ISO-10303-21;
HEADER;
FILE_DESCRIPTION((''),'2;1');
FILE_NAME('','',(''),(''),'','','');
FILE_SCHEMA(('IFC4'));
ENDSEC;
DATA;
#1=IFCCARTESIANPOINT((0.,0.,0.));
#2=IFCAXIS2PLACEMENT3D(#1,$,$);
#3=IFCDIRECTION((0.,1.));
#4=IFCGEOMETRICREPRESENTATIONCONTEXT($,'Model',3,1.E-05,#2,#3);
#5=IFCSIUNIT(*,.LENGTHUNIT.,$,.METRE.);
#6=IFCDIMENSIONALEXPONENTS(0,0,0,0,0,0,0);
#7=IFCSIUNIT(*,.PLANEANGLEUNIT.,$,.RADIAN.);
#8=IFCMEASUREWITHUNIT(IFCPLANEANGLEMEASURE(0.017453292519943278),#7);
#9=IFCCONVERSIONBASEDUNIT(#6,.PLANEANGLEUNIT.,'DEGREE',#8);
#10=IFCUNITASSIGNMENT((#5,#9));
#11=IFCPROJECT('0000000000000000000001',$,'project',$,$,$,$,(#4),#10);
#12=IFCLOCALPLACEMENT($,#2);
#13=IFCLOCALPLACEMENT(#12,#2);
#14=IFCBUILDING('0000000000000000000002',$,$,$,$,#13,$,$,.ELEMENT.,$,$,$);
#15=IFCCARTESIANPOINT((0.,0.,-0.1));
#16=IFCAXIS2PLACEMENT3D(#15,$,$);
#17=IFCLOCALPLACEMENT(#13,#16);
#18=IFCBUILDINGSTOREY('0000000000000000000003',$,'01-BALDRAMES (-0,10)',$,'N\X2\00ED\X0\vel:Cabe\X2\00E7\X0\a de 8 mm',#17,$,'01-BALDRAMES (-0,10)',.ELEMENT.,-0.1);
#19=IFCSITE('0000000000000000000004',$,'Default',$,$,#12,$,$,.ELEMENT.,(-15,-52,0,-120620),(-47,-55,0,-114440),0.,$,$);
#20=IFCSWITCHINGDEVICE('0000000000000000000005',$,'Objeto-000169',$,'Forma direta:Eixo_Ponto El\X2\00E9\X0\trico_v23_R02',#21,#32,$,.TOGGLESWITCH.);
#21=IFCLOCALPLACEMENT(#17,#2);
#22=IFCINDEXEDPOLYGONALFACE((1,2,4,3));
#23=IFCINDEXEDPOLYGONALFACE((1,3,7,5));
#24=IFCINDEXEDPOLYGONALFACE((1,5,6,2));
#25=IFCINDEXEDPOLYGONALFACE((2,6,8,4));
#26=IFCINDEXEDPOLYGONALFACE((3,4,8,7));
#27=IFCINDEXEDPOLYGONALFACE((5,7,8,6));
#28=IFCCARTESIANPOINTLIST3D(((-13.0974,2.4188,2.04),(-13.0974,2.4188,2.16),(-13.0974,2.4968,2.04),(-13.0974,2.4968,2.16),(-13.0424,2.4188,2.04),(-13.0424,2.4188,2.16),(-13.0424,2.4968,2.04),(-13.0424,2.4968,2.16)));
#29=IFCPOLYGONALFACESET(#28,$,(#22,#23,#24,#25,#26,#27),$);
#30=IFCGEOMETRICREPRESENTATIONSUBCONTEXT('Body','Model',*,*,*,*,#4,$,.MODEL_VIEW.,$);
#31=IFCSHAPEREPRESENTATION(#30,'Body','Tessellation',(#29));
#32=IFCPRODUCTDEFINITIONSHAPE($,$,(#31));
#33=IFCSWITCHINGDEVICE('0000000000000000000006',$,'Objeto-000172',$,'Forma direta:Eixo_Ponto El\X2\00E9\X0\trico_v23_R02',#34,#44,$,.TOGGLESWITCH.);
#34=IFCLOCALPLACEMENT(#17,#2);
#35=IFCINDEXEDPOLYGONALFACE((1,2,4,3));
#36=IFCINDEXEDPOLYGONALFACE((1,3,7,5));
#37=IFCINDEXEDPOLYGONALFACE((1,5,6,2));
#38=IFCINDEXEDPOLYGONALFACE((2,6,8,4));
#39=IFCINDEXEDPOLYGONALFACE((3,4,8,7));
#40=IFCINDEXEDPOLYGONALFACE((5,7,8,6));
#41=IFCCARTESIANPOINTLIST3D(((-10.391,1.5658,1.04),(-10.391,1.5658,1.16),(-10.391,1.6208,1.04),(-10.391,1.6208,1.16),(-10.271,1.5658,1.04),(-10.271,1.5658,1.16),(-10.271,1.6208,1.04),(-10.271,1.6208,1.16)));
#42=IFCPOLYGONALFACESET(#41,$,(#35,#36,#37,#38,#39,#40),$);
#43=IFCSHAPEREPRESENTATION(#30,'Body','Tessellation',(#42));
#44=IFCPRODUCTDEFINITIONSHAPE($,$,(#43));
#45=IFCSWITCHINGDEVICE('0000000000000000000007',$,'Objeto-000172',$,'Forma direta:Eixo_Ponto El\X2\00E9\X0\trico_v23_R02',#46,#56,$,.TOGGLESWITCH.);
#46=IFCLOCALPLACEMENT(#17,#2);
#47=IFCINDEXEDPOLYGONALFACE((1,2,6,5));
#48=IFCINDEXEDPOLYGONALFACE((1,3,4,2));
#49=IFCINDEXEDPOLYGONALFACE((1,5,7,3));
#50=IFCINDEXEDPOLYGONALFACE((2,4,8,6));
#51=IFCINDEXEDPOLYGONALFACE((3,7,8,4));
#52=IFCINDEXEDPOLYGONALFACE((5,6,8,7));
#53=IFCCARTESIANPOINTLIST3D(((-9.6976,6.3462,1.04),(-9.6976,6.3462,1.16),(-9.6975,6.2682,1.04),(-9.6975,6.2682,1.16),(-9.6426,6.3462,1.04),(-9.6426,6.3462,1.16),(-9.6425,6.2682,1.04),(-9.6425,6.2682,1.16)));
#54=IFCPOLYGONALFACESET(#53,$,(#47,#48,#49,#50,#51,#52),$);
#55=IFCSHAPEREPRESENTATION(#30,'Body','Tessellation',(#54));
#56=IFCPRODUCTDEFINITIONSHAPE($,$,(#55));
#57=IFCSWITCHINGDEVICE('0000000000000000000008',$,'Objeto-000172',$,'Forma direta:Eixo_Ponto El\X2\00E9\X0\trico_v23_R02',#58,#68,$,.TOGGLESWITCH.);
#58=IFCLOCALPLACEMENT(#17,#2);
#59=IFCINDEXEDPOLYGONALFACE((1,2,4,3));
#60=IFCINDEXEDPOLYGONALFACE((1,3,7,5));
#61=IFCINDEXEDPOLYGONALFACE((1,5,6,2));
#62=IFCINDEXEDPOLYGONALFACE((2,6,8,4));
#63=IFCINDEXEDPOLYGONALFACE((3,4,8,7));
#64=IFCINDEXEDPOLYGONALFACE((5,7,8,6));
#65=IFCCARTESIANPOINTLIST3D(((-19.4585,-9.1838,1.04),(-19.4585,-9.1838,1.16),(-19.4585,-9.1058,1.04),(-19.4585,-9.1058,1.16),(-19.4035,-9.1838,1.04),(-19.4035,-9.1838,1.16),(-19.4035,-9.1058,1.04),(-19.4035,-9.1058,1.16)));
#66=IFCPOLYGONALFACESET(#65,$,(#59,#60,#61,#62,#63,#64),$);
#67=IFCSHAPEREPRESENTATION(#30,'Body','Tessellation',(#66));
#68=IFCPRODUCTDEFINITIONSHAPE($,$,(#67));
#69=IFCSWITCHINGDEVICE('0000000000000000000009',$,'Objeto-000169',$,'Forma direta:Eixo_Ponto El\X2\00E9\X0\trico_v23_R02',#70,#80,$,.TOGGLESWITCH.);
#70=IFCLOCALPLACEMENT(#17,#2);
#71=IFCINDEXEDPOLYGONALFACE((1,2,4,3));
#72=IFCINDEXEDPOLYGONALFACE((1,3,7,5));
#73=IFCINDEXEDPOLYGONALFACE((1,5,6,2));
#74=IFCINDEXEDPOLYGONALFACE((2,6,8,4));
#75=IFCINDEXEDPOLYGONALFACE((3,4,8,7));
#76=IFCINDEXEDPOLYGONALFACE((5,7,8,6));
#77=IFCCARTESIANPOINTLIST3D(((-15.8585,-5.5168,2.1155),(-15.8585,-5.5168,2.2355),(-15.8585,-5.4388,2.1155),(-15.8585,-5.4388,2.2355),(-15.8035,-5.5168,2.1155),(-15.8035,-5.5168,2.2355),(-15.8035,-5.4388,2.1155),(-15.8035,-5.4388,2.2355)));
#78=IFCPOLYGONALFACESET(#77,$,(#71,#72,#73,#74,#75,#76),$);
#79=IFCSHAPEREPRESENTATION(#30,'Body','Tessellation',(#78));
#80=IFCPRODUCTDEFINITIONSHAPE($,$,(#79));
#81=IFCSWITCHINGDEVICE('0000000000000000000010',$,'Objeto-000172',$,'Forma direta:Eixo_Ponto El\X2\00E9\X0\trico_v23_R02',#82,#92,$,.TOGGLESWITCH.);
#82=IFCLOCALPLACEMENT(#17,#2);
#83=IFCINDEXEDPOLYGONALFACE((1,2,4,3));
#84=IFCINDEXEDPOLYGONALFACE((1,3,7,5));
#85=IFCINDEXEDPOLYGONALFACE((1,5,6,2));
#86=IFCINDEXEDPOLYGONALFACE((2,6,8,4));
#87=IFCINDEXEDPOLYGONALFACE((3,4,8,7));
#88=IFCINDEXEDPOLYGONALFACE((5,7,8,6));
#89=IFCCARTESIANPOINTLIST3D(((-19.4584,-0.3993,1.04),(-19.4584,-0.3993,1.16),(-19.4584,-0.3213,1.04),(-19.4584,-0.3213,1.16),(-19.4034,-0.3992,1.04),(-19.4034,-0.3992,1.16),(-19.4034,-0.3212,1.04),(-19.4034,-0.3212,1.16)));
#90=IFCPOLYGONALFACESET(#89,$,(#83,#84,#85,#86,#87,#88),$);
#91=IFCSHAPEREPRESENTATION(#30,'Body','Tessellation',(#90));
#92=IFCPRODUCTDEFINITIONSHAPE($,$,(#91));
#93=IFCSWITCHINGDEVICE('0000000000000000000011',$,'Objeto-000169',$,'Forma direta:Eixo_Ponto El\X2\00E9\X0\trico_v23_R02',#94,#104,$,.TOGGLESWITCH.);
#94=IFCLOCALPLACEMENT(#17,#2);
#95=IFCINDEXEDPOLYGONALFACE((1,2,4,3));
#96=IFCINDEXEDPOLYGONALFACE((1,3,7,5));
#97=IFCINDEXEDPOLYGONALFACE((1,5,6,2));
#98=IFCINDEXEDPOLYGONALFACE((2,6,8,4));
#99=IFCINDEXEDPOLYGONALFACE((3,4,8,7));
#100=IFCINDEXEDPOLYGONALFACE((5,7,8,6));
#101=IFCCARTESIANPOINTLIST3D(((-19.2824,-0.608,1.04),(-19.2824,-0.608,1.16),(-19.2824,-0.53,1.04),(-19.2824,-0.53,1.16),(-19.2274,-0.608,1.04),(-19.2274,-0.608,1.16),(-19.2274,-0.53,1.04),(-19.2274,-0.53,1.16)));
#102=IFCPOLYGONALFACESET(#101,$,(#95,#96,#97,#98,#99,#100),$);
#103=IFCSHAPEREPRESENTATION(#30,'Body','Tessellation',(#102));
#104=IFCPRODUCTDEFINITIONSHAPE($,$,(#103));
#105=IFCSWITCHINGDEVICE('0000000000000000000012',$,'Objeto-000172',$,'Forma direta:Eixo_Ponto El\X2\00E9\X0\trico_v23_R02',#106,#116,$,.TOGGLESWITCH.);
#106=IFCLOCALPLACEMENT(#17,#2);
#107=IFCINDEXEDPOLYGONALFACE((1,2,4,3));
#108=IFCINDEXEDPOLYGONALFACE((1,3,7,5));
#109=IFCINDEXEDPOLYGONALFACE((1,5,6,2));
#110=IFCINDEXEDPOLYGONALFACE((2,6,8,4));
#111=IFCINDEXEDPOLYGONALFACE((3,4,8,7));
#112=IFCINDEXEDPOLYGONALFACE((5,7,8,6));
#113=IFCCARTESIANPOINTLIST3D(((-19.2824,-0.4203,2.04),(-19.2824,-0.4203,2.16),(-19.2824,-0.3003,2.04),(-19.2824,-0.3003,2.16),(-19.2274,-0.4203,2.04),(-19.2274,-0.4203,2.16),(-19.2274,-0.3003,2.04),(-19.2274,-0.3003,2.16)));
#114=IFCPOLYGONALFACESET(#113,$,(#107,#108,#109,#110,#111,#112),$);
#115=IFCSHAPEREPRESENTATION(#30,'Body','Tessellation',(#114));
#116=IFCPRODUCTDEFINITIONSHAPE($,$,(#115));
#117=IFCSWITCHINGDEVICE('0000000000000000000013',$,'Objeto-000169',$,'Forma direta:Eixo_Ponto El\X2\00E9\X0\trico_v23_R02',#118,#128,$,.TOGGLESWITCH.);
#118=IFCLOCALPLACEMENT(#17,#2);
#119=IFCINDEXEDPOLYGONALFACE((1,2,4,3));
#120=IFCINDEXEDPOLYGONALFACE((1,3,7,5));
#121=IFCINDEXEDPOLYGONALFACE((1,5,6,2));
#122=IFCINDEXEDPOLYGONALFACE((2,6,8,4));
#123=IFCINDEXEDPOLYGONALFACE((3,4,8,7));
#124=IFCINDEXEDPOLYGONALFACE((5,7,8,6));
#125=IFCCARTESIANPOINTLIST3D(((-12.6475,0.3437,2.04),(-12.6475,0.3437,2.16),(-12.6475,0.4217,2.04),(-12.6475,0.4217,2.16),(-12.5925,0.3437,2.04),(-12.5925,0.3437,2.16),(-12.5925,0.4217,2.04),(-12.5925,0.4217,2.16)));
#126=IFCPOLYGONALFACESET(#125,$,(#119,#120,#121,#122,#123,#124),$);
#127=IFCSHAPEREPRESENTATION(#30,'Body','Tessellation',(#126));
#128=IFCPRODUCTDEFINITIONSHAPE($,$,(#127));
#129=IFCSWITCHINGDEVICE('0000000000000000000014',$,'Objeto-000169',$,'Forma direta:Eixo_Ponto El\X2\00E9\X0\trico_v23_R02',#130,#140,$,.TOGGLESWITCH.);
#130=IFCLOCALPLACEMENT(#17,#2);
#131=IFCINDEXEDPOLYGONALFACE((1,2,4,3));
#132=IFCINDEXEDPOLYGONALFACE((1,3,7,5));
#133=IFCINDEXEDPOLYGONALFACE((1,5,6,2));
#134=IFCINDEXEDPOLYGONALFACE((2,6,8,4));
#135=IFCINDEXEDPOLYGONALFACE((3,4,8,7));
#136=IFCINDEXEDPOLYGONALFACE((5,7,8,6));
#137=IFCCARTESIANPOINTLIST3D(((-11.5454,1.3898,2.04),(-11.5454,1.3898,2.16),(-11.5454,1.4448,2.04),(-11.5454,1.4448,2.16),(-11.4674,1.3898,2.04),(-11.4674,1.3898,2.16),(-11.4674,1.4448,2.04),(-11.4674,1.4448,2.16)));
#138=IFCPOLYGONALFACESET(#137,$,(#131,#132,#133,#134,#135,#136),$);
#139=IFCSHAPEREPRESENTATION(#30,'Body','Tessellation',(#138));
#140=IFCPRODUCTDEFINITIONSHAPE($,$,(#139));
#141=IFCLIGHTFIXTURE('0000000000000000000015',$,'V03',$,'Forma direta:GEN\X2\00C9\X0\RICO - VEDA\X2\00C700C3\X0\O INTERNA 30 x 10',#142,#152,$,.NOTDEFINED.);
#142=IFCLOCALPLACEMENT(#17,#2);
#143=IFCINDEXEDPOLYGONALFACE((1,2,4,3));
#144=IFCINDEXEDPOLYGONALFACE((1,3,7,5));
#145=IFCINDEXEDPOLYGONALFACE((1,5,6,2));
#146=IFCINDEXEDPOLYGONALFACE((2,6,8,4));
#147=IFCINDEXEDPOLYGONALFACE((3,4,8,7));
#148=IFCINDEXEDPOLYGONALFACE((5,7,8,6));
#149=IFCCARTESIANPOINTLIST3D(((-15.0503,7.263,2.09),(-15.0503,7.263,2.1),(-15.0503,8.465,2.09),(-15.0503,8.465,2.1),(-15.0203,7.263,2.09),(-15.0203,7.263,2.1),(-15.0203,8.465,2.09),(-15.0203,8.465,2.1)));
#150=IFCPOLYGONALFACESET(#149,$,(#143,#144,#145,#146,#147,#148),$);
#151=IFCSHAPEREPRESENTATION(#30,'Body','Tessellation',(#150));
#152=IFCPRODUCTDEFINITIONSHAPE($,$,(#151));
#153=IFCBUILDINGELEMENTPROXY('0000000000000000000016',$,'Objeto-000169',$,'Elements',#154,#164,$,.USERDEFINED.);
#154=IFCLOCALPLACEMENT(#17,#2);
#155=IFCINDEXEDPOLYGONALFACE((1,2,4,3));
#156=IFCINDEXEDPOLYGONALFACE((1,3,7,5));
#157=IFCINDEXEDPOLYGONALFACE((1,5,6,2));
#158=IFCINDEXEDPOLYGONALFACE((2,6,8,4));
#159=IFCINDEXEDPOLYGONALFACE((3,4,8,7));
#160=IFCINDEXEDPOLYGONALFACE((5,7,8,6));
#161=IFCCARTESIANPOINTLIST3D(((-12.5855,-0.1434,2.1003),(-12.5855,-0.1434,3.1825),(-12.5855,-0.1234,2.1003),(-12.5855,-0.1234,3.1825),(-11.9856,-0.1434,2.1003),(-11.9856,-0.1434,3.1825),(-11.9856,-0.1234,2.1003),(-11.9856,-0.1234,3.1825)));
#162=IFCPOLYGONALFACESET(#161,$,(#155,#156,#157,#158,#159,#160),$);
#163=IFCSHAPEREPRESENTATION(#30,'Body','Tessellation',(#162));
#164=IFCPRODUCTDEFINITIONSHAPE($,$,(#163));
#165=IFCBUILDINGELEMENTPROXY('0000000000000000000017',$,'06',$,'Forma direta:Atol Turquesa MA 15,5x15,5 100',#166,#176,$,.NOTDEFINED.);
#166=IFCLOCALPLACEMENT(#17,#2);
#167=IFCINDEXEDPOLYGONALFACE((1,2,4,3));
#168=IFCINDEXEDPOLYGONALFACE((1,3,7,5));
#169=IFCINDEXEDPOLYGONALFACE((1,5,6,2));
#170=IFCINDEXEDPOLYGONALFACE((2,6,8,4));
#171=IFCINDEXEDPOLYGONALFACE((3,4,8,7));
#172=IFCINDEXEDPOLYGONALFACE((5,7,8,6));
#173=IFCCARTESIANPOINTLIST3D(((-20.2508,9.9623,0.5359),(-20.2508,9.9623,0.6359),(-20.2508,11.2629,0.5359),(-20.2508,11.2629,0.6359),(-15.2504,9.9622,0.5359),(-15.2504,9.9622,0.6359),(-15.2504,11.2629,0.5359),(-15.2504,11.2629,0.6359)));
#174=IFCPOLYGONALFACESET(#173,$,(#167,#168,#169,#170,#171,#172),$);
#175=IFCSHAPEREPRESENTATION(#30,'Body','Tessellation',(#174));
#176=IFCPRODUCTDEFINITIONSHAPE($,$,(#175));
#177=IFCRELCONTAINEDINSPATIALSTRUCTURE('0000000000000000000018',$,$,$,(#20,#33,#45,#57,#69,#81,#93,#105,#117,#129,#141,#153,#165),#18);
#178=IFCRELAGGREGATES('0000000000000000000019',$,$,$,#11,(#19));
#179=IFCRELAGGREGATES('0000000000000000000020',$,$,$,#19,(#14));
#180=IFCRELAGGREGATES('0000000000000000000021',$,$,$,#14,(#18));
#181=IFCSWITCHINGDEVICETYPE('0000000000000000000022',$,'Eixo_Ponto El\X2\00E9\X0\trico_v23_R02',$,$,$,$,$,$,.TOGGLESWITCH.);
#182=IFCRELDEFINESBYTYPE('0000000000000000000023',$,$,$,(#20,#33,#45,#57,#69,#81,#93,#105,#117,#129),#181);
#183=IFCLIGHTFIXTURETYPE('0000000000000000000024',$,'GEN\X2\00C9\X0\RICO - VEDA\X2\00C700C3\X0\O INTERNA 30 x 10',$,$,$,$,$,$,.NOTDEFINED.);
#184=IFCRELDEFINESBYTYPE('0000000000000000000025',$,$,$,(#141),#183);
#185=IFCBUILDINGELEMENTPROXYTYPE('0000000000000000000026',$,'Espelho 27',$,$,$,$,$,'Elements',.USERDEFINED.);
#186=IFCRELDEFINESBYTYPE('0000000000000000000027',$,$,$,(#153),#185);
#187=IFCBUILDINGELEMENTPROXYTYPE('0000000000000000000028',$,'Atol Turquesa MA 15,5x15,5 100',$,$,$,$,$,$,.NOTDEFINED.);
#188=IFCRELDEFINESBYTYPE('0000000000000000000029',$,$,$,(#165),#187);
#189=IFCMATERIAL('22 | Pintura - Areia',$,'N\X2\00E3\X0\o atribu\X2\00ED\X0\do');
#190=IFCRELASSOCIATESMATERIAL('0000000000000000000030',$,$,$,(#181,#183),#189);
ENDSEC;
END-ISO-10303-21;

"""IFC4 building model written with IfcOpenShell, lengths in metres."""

from ifc_helpers import new_model, entity, si_unit, converted_unit, direction, frame, origin, place, context, subcontext, project, spatial, indexed_curve, outline, extrude, material, type_object, element, save


model = new_model("IFC4")

# Units and contexts
model_context = context("Model", 3, precision=1e-05, world=origin(), true_north=direction((0.0, 1.0)))
body_context = subcontext(model_context, "Body", "Model", "MODEL_VIEW")
ifc_project = project(units=[si_unit("LENGTHUNIT", "METRE"), converted_unit("PLANEANGLEUNIT", "DEGREE", entity("IfcPlaneAngleMeasure", 0.017453292519943278), si_unit("PLANEANGLEUNIT", "RADIAN"), dimensions=[0, 0, 0, 0, 0, 0, 0])], contexts=[model_context])

# Site, building, storey
site_placement = place(None, origin())
site = spatial("IfcSite", under=ifc_project, at=site_placement, Name="Default", CompositionType="ELEMENT", RefLatitude=(-15, -52, 0, -120620), RefLongitude=(-47, -55, 0, -114440), RefElevation=0.0)
building_placement = place(site_placement, origin())
building = spatial("IfcBuilding", under=site, at=building_placement, CompositionType="ELEMENT")
storey_placement = place(building_placement, frame((0.0, 0.0, -0.1)))
storey = spatial("IfcBuildingStorey", under=building, at=storey_placement, Name="01-BALDRAMES (-0,10)", ObjectType="Nível:Cabeça de 8 mm", LongName="01-BALDRAMES (-0,10)", CompositionType="ELEMENT", Elevation=-0.1)

# Switching devices
ifc_material_1 = material(Name="22 | Pintura - Areia", Category="Não atribuído")
switching_device_type = type_object("IfcSwitchingDeviceType", Name="Eixo_Ponto Elétrico_v23_R02", PredefinedType="TOGGLESWITCH", material=ifc_material_1)
switching_device_1_placement = place(storey_placement, origin())
element("IfcSwitchingDevice", 1, at=switching_device_1_placement, inside=storey, type_object=switching_device_type, Name="Objeto-000169", ObjectType="Forma direta:Eixo_Ponto Elétrico_v23_R02", PredefinedType="TOGGLESWITCH", context=body_context, shape_type="SweptSolid", body=[
    extrude(outline(indexed_curve([(-0.0275, -0.039), (0.0275, -0.039), (0.0275, 0.039), (-0.0275, 0.039), (-0.0275, -0.039)], self_intersect=False)), frame((-13.0699, 2.4578, 2.04), z_axis=(0.0, 0.0, 1.0), x_axis=(-1.0, 0.000013, 0.0)), (0.0, 0.0, 1.0), 0.12),
])
switching_device_2_placement = place(storey_placement, origin())
element("IfcSwitchingDevice", 2, at=switching_device_2_placement, inside=storey, type_object=switching_device_type, Name="Objeto-000172", ObjectType="Forma direta:Eixo_Ponto Elétrico_v23_R02", PredefinedType="TOGGLESWITCH", context=body_context, shape_type="SweptSolid", body=[
    extrude(outline(indexed_curve([(-0.0275, -0.06), (0.0275, -0.06), (0.0275, 0.06), (-0.0275, 0.06), (-0.0275, -0.06)], self_intersect=False)), frame((-10.331, 1.5933, 1.04), z_axis=(0.0, 0.0, 1.0), x_axis=(-0.000013, -1.0, 0.0)), (0.0, 0.0, 1.0), 0.12),
])
switching_device_3_placement = place(storey_placement, origin())
element("IfcSwitchingDevice", 3, at=switching_device_3_placement, inside=storey, type_object=switching_device_type, Name="Objeto-000172", ObjectType="Forma direta:Eixo_Ponto Elétrico_v23_R02", PredefinedType="TOGGLESWITCH", context=body_context, shape_type="SweptSolid", body=[
    extrude(outline(indexed_curve([(-0.0275, -0.039), (0.0275, -0.039), (0.0275, 0.039), (-0.0275, 0.039), (-0.0275, -0.039)], self_intersect=False)), frame((-9.67, 6.3072, 1.04), z_axis=(0.0, 0.0, 1.0), x_axis=(-1.0, -0.000191, 0.0)), (0.0, 0.0, 1.0), 0.12),
])
switching_device_4_placement = place(storey_placement, origin())
element("IfcSwitchingDevice", 4, at=switching_device_4_placement, inside=storey, type_object=switching_device_type, Name="Objeto-000172", ObjectType="Forma direta:Eixo_Ponto Elétrico_v23_R02", PredefinedType="TOGGLESWITCH", context=body_context, shape_type="SweptSolid", body=[
    extrude(outline(indexed_curve([(-0.0275, -0.039), (0.0275, -0.039), (0.0275, 0.039), (-0.0275, 0.039), (-0.0275, -0.039)], self_intersect=False)), frame((-19.431, -9.1448, 1.04), z_axis=(0.0, 0.0, 1.0), x_axis=(1.0, 0.000186, 0.0)), (0.0, 0.0, 1.0), 0.12),
])
switching_device_5_placement = place(storey_placement, origin())
element("IfcSwitchingDevice", 5, at=switching_device_5_placement, inside=storey, type_object=switching_device_type, Name="Objeto-000169", ObjectType="Forma direta:Eixo_Ponto Elétrico_v23_R02", PredefinedType="TOGGLESWITCH", context=body_context, shape_type="SweptSolid", body=[
    extrude(outline(indexed_curve([(-0.0275, -0.039), (0.0275, -0.039), (0.0275, 0.039), (-0.0275, 0.039), (-0.0275, -0.039)], self_intersect=False)), frame((-15.831, -5.4778, 2.1155)), (0.0, 0.0, 1.0), 0.12),
])
switching_device_6_placement = place(storey_placement, origin())
element("IfcSwitchingDevice", 6, at=switching_device_6_placement, inside=storey, type_object=switching_device_type, Name="Objeto-000172", ObjectType="Forma direta:Eixo_Ponto Elétrico_v23_R02", PredefinedType="TOGGLESWITCH", context=body_context, shape_type="SweptSolid", body=[
    extrude(outline(indexed_curve([(-0.0275, -0.039), (0.0275, -0.039), (0.0275, 0.039), (-0.0275, 0.039), (-0.0275, -0.039)], self_intersect=False)), frame((-19.4309, -0.3603, 1.04), z_axis=(0.0, 0.0, 1.0), x_axis=(1.0, 0.000186, 0.0)), (0.0, 0.0, 1.0), 0.12),
])
switching_device_7_placement = place(storey_placement, origin())
element("IfcSwitchingDevice", 7, at=switching_device_7_placement, inside=storey, type_object=switching_device_type, Name="Objeto-000169", ObjectType="Forma direta:Eixo_Ponto Elétrico_v23_R02", PredefinedType="TOGGLESWITCH", context=body_context, shape_type="SweptSolid", body=[
    extrude(outline(indexed_curve([(-0.0275, -0.039), (0.0275, -0.039), (0.0275, 0.039), (-0.0275, 0.039), (-0.0275, -0.039)], self_intersect=False)), frame((-19.2549, -0.569, 1.04), z_axis=(0.0, 0.0, 1.0), x_axis=(-1.0, 0.000013, 0.0)), (0.0, 0.0, 1.0), 0.12),
])
switching_device_8_placement = place(storey_placement, origin())
element("IfcSwitchingDevice", 8, at=switching_device_8_placement, inside=storey, type_object=switching_device_type, Name="Objeto-000172", ObjectType="Forma direta:Eixo_Ponto Elétrico_v23_R02", PredefinedType="TOGGLESWITCH", context=body_context, shape_type="SweptSolid", body=[
    extrude(outline(indexed_curve([(-0.0275, -0.06), (0.0275, -0.06), (0.0275, 0.06), (-0.0275, 0.06), (-0.0275, -0.06)], self_intersect=False)), frame((-19.2549, -0.3603, 2.04), z_axis=(0.0, 0.0, 1.0), x_axis=(-1.0, 0.000013, 0.0)), (0.0, 0.0, 1.0), 0.12),
])
switching_device_9_placement = place(storey_placement, origin())
element("IfcSwitchingDevice", 9, at=switching_device_9_placement, inside=storey, type_object=switching_device_type, Name="Objeto-000169", ObjectType="Forma direta:Eixo_Ponto Elétrico_v23_R02", PredefinedType="TOGGLESWITCH", context=body_context, shape_type="SweptSolid", body=[
    extrude(outline(indexed_curve([(-0.0275, -0.039), (0.0275, -0.039), (0.0275, 0.039), (-0.0275, 0.039), (-0.0275, -0.039)], self_intersect=False)), frame((-12.62, 0.3827, 2.04), z_axis=(0.0, 0.0, 1.0), x_axis=(-1.0, 0.000011, 0.0)), (0.0, 0.0, 1.0), 0.12),
])
switching_device_10_placement = place(storey_placement, origin())
element("IfcSwitchingDevice", 10, at=switching_device_10_placement, inside=storey, type_object=switching_device_type, Name="Objeto-000169", ObjectType="Forma direta:Eixo_Ponto Elétrico_v23_R02", PredefinedType="TOGGLESWITCH", context=body_context, shape_type="SweptSolid", body=[
    extrude(outline(indexed_curve([(-0.0275, -0.039), (0.0275, -0.039), (0.0275, 0.039), (-0.0275, 0.039), (-0.0275, -0.039)], self_intersect=False)), frame((-11.5064, 1.4173, 2.04), z_axis=(0.0, 0.0, 1.0), x_axis=(0.000013, 1.0, 0.0)), (0.0, 0.0, 1.0), 0.12),
])

# Light fixture
light_fixture_type = type_object("IfcLightFixtureType", Name="GENÉRICO - VEDAÇÃO INTERNA 30 x 10", PredefinedType="NOTDEFINED", material=ifc_material_1)
light_fixture_placement = place(storey_placement, origin())
element("IfcLightFixture", 11, at=light_fixture_placement, inside=storey, type_object=light_fixture_type, Name="V03", ObjectType="Forma direta:GENÉRICO - VEDAÇÃO INTERNA 30 x 10", PredefinedType="NOTDEFINED", context=body_context, shape_type="SweptSolid", body=[
    extrude(outline(indexed_curve([(-0.601, -0.015), (0.601, -0.015), (0.601, 0.015), (-0.601, 0.015), (-0.601, -0.015)], self_intersect=False)), frame((-15.0353, 7.864, 2.09), z_axis=(0.0, 0.0, 1.0), x_axis=(-0.000013, -1.0, 0.0)), (0.0, 0.0, 1.0), 0.01),
])

# Building element proxies
building_element_proxy_type_1 = type_object("IfcBuildingElementProxyType", Name="Espelho 27", ElementType="Elements", PredefinedType="USERDEFINED")
proxy_1_placement = place(storey_placement, origin())
element("IfcBuildingElementProxy", 12, at=proxy_1_placement, inside=storey, type_object=building_element_proxy_type_1, Name="Objeto-000169", ObjectType="Elements", PredefinedType="USERDEFINED", context=body_context, shape_type="SweptSolid", body=[
    extrude(outline(indexed_curve([(-0.2999, -0.01), (0.2999, -0.01), (0.2999, 0.01), (-0.2999, 0.01), (-0.2999, -0.01)], self_intersect=False)), frame((-12.2855, -0.1334, 2.1003), z_axis=(0.0, 0.0, 1.0), x_axis=(-1.0, 0.000013, 0.0)), (0.0, 0.0, 1.0), 1.0822),
])
building_element_proxy_type_2 = type_object("IfcBuildingElementProxyType", Name="Atol Turquesa MA 15,5x15,5 100", PredefinedType="NOTDEFINED")
proxy_2_placement = place(storey_placement, origin())
element("IfcBuildingElementProxy", 13, at=proxy_2_placement, inside=storey, type_object=building_element_proxy_type_2, Name="06", ObjectType="Forma direta:Atol Turquesa MA 15,5x15,5 100", PredefinedType="NOTDEFINED", context=body_context, shape_type="SweptSolid", body=[
    extrude(outline(indexed_curve([(-0.6503, -2.5002), (0.6503, -2.5002), (0.6503, 2.5002), (-0.6503, 2.5002), (-0.6503, -2.5002)], self_intersect=False)), frame((-17.7506, 10.6126, 0.5359), z_axis=(0.0, 0.0, 1.0), x_axis=(0.000013, 1.0, 0.0)), (0.0, 0.0, 1.0), 0.1),
])

save(model, "model.ifc")
